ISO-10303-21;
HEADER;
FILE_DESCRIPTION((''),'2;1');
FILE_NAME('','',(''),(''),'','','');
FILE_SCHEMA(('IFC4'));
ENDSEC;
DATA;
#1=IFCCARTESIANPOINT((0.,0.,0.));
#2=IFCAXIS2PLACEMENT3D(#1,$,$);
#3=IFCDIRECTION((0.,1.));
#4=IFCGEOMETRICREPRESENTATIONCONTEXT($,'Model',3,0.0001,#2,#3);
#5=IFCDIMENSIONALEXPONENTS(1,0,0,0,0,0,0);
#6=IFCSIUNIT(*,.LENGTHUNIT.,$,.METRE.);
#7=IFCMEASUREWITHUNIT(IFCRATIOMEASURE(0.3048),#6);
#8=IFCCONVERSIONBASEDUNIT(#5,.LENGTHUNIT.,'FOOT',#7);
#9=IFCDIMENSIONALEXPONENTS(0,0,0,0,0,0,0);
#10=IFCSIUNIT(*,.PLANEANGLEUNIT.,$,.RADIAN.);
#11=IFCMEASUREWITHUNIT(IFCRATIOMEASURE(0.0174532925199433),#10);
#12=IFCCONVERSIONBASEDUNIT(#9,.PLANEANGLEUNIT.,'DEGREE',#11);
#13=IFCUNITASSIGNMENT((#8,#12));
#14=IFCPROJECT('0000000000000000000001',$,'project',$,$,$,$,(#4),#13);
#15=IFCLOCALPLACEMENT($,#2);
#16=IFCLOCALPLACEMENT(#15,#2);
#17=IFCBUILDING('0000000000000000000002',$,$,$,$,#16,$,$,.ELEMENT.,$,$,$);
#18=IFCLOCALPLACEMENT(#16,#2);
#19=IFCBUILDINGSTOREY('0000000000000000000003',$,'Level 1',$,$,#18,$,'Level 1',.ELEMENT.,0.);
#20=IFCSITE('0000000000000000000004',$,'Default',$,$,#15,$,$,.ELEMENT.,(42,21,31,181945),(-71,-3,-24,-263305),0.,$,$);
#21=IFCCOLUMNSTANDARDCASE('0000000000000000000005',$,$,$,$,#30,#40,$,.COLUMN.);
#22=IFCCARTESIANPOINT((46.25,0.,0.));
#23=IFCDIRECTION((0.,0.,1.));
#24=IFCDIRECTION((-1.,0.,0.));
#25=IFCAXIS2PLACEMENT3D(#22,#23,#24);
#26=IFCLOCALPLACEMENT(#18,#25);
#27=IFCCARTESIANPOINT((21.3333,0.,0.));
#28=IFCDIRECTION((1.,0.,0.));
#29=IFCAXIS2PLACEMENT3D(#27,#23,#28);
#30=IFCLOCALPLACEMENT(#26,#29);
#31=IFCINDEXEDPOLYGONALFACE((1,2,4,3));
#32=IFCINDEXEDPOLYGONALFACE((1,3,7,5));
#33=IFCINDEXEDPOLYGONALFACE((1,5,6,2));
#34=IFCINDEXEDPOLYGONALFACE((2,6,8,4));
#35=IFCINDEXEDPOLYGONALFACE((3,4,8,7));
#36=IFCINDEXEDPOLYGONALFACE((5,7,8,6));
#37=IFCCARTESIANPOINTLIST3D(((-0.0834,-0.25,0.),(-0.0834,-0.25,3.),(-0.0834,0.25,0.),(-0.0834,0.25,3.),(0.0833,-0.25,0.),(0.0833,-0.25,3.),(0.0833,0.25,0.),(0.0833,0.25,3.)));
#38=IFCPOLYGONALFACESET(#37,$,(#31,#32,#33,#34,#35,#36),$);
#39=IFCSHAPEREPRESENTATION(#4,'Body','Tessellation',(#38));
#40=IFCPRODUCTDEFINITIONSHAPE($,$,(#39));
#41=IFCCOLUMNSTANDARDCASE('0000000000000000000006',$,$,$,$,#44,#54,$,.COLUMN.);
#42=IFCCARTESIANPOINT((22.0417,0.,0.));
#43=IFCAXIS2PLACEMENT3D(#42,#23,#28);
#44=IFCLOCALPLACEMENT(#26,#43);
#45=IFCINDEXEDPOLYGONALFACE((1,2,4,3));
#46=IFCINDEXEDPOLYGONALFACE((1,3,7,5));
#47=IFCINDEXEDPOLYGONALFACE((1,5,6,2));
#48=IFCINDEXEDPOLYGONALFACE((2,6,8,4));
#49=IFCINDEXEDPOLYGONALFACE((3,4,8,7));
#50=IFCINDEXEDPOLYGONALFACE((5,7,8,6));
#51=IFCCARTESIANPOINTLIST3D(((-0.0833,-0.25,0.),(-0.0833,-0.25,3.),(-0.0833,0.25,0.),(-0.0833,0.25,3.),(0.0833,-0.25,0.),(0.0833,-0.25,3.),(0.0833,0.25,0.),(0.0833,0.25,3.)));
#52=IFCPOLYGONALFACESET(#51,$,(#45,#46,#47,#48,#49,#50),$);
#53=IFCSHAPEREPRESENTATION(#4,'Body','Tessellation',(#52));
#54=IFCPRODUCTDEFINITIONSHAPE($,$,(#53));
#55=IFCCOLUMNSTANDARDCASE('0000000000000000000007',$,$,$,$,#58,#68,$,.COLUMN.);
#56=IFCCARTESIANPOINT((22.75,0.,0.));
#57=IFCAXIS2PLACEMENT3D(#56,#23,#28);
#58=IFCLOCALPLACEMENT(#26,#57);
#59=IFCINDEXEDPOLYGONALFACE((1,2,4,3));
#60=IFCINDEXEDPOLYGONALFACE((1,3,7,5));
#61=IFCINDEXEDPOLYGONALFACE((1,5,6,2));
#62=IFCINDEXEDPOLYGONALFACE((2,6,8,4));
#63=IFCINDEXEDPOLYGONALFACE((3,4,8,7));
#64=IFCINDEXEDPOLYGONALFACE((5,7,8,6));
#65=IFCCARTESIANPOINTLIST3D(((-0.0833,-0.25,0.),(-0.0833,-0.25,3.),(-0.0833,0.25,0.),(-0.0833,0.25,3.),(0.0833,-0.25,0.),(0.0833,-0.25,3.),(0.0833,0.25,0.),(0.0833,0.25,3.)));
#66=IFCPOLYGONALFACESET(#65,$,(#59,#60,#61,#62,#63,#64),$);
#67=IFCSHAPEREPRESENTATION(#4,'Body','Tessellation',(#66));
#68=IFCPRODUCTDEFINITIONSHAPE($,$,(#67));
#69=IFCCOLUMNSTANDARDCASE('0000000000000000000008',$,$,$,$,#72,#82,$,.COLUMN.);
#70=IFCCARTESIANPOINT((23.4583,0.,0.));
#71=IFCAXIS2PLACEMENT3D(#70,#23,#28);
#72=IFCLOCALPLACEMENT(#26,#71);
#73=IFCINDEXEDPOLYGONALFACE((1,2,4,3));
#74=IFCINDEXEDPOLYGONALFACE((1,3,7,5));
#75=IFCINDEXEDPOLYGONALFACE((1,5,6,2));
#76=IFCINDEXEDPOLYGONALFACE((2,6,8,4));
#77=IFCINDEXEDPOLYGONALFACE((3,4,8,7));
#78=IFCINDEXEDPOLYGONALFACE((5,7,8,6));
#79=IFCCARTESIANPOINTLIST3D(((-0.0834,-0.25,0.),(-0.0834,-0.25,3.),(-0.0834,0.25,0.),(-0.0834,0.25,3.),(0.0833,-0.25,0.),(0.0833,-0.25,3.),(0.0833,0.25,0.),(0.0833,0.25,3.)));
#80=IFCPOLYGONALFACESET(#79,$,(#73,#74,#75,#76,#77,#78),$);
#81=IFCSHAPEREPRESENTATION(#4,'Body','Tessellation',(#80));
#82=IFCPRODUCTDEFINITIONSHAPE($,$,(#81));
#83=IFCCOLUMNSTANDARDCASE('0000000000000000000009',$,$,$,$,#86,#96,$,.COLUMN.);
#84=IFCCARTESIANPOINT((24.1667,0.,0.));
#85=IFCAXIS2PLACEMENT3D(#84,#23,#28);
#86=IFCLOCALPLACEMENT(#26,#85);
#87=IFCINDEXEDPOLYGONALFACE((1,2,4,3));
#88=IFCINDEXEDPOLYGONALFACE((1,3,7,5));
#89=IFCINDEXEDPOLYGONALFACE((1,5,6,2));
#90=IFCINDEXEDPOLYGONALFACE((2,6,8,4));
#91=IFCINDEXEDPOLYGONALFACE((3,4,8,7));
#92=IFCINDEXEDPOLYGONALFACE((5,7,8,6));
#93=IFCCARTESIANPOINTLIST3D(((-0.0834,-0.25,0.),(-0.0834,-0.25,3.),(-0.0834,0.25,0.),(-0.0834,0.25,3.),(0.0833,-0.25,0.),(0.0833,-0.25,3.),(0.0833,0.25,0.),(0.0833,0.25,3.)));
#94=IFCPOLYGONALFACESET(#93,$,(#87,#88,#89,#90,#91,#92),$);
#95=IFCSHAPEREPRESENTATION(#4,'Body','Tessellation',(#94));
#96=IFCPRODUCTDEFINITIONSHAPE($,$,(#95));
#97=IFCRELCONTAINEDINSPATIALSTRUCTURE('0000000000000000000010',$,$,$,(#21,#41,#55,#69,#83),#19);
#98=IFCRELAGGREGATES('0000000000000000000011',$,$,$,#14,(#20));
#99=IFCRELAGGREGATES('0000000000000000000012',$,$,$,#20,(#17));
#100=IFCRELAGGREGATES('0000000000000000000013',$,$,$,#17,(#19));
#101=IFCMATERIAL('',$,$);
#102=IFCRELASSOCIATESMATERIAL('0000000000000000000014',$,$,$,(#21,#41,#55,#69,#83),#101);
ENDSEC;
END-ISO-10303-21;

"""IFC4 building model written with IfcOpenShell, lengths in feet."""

from ifc_helpers import new_model, entity, si_unit, converted_unit, direction, frame, origin, place, context, project, spatial, rectangle, extrude, material, element, save


model = new_model("IFC4")

# Units and contexts
model_context = context("Model", 3, precision=0.0001, world=origin(), true_north=direction((0.0, 1.0)))
ifc_project = project(units=[converted_unit("LENGTHUNIT", "FOOT", entity("IfcRatioMeasure", 0.3048), si_unit("LENGTHUNIT", "METRE"), dimensions=[1, 0, 0, 0, 0, 0, 0]), converted_unit("PLANEANGLEUNIT", "DEGREE", entity("IfcRatioMeasure", 0.0174532925199433), si_unit("PLANEANGLEUNIT", "RADIAN"), dimensions=[0, 0, 0, 0, 0, 0, 0])], contexts=[model_context])

# Site, building, storey
site_placement = place(None, origin())
site = spatial("IfcSite", under=ifc_project, at=site_placement, Name="Default", CompositionType="ELEMENT", RefLatitude=(42, 21, 31, 181945), RefLongitude=(-71, -3, -24, -263305), RefElevation=0.0)
building_placement = place(site_placement, origin())
building = spatial("IfcBuilding", under=site, at=building_placement, CompositionType="ELEMENT")
storey_placement = place(building_placement, origin())
storey = spatial("IfcBuildingStorey", under=building, at=storey_placement, Name="Level 1", LongName="Level 1", CompositionType="ELEMENT", Elevation=0.0)

# Columns
placement = place(storey_placement, frame((46.25, 0.0, 0.0), z_axis=(0.0, 0.0, 1.0), x_axis=(-1.0, 0.0, 0.0)))
ifc_material_1 = material(Name="")
for number, where, z_axis, x_axis in (
    (1, (21.3333, 0.0, 0.0), (0.0, 0.0, 1.0), (1.0, 0.0, 0.0)),
    (2, (22.0417, 0.0, 0.0), (0.0, 0.0, 1.0), (1.0, 0.0, 0.0)),
    (3, (22.75, 0.0, 0.0), (0.0, 0.0, 1.0), (1.0, 0.0, 0.0)),
    (4, (23.4583, 0.0, 0.0), (0.0, 0.0, 1.0), (1.0, 0.0, 0.0)),
    (5, (24.1667, 0.0, 0.0), (0.0, 0.0, 1.0), (1.0, 0.0, 0.0)),
):
    element("IfcColumnStandardCase", number, at=place(placement, frame(where, z_axis=z_axis, x_axis=x_axis)), inside=storey, material=ifc_material_1, PredefinedType="COLUMN", context=model_context, shape_type="SweptSolid", body=[
        extrude(rectangle(XDim=0.1667, YDim=0.5), origin(), (0.0, 0.0, 1.0), 3.0),
    ])

save(model, "model.ifc")
